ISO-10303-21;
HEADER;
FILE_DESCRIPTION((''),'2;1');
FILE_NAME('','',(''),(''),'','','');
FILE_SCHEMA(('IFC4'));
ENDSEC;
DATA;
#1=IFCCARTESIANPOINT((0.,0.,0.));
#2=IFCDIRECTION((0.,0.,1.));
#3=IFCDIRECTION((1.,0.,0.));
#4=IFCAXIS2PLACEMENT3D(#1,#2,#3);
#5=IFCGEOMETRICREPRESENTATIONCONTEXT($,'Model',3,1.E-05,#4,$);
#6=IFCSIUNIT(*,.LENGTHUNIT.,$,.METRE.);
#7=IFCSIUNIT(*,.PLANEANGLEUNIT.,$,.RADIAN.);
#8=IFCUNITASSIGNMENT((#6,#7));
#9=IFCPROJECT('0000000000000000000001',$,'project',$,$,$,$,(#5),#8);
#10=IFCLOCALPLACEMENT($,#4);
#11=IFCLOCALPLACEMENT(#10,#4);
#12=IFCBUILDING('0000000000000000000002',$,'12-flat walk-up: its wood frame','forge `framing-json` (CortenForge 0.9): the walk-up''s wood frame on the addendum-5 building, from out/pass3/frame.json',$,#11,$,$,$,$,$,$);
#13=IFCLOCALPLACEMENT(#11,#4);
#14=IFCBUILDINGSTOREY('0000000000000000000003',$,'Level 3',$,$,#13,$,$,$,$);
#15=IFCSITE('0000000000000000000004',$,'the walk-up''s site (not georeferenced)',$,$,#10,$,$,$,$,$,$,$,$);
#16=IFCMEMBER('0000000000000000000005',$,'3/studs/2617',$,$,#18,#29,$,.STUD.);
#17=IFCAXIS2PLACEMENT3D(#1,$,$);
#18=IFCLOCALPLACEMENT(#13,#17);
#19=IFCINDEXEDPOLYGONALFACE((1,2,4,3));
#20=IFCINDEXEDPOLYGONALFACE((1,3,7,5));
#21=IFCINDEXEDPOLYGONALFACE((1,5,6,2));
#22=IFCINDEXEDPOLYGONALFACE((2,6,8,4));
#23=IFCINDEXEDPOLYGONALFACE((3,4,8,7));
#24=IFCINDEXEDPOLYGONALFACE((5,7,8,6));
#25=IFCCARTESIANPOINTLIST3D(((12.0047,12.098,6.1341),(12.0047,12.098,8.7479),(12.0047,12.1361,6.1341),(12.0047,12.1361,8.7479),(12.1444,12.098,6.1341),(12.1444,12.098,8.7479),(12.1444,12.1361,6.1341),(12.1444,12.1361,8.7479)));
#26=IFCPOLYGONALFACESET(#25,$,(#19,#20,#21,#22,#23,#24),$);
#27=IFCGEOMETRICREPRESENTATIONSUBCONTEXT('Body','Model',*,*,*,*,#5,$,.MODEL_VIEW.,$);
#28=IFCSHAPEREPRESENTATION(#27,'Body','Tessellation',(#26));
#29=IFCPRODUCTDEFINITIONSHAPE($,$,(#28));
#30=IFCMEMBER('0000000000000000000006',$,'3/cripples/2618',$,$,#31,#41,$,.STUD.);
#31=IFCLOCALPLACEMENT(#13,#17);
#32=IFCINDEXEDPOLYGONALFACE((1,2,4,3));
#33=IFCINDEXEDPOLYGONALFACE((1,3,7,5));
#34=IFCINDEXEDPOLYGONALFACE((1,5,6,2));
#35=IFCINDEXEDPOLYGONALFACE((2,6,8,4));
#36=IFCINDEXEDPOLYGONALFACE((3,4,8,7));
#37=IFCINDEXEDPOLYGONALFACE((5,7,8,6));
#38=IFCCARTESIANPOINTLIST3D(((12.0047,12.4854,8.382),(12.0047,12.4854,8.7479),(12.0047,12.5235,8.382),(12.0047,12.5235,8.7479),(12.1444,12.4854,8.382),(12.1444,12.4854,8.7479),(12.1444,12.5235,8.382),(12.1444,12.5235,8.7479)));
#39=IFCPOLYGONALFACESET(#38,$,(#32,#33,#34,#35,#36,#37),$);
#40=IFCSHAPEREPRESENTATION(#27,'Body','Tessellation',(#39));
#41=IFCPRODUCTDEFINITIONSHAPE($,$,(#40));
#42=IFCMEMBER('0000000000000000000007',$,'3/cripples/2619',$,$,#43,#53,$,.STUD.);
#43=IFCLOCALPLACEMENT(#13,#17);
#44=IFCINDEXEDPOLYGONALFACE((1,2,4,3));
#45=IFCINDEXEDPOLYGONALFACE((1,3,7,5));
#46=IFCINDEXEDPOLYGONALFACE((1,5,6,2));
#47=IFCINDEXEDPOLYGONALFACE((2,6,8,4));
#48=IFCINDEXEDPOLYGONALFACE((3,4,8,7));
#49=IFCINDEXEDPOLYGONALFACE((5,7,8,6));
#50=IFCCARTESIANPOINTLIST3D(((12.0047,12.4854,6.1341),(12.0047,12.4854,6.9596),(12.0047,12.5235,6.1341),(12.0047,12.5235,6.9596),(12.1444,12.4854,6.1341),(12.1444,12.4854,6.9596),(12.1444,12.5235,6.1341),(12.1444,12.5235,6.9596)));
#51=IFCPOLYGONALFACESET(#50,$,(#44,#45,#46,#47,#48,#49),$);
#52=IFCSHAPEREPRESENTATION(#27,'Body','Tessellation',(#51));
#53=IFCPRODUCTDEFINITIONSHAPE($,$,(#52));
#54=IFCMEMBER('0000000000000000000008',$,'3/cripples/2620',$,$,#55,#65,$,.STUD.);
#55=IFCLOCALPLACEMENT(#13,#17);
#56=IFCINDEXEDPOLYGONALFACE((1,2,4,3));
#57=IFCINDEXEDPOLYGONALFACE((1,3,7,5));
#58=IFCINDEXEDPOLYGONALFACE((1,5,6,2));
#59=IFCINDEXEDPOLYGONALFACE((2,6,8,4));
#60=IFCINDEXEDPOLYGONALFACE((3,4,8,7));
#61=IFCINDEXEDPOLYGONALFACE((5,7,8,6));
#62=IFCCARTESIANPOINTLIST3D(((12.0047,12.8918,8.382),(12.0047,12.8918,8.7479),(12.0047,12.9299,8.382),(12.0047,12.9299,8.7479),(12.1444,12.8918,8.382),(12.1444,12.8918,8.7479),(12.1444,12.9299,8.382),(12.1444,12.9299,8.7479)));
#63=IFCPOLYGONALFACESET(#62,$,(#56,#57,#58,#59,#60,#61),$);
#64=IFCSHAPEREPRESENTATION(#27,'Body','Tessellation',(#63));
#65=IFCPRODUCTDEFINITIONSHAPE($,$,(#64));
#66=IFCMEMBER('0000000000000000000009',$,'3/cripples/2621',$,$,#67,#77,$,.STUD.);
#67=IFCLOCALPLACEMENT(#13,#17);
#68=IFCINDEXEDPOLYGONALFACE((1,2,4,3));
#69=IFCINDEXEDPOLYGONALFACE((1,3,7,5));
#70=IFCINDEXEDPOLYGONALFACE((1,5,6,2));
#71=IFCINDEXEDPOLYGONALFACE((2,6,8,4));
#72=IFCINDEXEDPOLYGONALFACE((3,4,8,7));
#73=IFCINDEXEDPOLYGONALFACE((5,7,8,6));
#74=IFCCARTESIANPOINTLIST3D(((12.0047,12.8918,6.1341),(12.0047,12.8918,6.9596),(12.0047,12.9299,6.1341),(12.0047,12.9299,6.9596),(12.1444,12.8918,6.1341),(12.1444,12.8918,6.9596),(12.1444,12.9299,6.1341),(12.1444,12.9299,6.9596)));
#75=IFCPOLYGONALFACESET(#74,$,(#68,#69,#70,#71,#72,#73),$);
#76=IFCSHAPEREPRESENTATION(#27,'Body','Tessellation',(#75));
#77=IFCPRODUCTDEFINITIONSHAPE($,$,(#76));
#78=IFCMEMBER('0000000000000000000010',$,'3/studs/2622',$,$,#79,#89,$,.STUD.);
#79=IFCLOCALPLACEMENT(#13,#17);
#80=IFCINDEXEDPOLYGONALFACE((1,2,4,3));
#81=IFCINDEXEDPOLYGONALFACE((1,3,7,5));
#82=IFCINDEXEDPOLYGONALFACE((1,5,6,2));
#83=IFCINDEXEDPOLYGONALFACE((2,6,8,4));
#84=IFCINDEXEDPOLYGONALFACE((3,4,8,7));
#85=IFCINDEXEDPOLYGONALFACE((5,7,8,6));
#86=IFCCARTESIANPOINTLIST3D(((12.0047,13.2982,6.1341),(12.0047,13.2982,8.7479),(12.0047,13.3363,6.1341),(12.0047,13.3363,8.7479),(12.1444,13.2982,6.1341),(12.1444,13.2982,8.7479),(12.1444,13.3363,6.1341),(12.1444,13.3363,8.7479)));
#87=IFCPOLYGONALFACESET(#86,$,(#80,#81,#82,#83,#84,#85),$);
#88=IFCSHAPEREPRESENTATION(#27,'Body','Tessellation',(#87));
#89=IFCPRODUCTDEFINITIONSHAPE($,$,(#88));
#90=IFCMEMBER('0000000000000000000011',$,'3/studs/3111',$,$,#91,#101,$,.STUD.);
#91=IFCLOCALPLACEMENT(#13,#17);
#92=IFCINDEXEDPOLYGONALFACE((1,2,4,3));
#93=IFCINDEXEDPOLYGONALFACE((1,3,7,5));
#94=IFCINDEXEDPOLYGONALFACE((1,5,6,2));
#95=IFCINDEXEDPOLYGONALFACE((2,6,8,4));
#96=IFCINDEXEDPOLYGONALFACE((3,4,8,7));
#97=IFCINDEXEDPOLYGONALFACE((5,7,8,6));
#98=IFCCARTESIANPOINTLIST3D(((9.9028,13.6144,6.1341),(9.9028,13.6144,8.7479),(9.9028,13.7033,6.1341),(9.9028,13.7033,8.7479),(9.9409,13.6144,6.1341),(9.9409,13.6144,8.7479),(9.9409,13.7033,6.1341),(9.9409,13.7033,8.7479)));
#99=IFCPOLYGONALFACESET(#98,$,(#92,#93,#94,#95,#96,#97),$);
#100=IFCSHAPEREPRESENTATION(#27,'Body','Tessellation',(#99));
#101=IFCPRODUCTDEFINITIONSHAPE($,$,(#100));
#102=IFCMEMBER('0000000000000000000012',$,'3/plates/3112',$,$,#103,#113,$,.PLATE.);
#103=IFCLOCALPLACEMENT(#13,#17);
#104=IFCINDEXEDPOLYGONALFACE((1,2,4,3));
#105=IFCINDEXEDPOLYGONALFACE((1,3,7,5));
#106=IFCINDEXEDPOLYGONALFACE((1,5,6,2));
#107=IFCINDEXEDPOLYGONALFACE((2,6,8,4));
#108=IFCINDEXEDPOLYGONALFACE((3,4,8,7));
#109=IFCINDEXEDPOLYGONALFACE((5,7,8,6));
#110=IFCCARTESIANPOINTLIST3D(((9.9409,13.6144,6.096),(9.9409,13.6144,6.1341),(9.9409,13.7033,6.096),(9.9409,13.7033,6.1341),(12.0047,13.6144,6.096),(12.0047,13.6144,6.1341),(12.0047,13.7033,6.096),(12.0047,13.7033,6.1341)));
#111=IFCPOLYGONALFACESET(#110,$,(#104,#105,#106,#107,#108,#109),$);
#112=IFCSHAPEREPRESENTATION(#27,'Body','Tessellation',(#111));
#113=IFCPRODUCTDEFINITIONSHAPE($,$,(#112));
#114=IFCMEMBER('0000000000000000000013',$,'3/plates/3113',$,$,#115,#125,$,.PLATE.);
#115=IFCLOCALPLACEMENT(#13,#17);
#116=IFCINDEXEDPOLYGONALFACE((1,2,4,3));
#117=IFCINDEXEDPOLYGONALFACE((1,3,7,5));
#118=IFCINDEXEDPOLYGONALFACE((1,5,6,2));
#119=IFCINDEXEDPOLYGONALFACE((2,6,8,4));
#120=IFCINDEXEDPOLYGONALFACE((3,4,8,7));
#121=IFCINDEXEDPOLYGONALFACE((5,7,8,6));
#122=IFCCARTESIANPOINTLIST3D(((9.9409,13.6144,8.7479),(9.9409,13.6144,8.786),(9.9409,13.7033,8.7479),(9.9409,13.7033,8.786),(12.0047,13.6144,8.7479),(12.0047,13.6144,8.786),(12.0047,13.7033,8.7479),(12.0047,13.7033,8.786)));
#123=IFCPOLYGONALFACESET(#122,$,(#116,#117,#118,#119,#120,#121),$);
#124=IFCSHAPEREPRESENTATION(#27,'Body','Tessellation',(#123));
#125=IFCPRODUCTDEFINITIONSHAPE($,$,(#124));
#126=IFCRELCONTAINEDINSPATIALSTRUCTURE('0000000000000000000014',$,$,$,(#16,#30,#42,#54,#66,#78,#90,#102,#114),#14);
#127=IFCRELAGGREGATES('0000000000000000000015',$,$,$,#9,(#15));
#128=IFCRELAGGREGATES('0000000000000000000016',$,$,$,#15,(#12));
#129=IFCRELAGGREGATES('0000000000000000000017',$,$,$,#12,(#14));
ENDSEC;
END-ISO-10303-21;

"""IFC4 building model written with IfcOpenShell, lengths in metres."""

from ifc_helpers import new_model, si_unit, frame, frame_2d, origin, origin_with_axes, place, context, subcontext, project, spatial, rectangle, extrude, element, save


model = new_model("IFC4")

# Units and contexts
model_context = context("Model", 3, precision=1e-05, world=origin_with_axes())
body_context = subcontext(model_context, "Body", "Model", "MODEL_VIEW")
ifc_project = project(units=[si_unit("LENGTHUNIT", "METRE"), si_unit("PLANEANGLEUNIT", "RADIAN")], contexts=[model_context])

# Site, building, storey
site_placement = place(None, origin_with_axes())
site = spatial("IfcSite", under=ifc_project, at=site_placement, Name="the walk-up's site (not georeferenced)")
building_placement = place(site_placement, origin_with_axes())
building = spatial("IfcBuilding", under=site, at=building_placement, Name="12-flat walk-up: its wood frame", Description="forge `framing-json` (CortenForge 0.9): the walk-up's wood frame on the addendum-5 building, from out/pass3/frame.json")
storey_placement = place(building_placement, origin_with_axes())
storey = spatial("IfcBuildingStorey", under=building, at=storey_placement, Name="Level 3")

# Members
member_1_placement = place(storey_placement, frame((12.0047, 12.098, 6.1341), z_axis=(0.0, 0.0, 1.0), x_axis=(1.0, 0.0, 0.0)))
element("IfcMember", 1, at=member_1_placement, inside=storey, Name="3/studs/2617", PredefinedType="STUD", context=body_context, shape_type="SweptSolid", body=[
    extrude(rectangle(XDim=0.1397, YDim=0.0381, at=frame_2d((0.0698, 0.0191))), origin(), (0.0, 0.0, 1.0), 2.6138),
])
member_2_placement = place(storey_placement, frame((12.0047, 12.4854, 8.382), z_axis=(0.0, 0.0, 1.0), x_axis=(1.0, 0.0, 0.0)))
element("IfcMember", 2, at=member_2_placement, inside=storey, Name="3/cripples/2618", PredefinedType="STUD", context=body_context, shape_type="SweptSolid", body=[
    extrude(rectangle(XDim=0.1397, YDim=0.0381, at=frame_2d((0.0698, 0.0191))), origin(), (0.0, 0.0, 1.0), 0.3659),
])
member_3_placement = place(storey_placement, frame((12.0047, 12.4854, 6.1341), z_axis=(0.0, 0.0, 1.0), x_axis=(1.0, 0.0, 0.0)))
element("IfcMember", 3, at=member_3_placement, inside=storey, Name="3/cripples/2619", PredefinedType="STUD", context=body_context, shape_type="SweptSolid", body=[
    extrude(rectangle(XDim=0.1397, YDim=0.0381, at=frame_2d((0.0698, 0.0191))), origin(), (0.0, 0.0, 1.0), 0.8255),
])
member_4_placement = place(storey_placement, frame((12.0047, 12.8918, 8.382), z_axis=(0.0, 0.0, 1.0), x_axis=(1.0, 0.0, 0.0)))
element("IfcMember", 4, at=member_4_placement, inside=storey, Name="3/cripples/2620", PredefinedType="STUD", context=body_context, shape_type="SweptSolid", body=[
    extrude(rectangle(XDim=0.1397, YDim=0.0381, at=frame_2d((0.0698, 0.019))), origin(), (0.0, 0.0, 1.0), 0.3659),
])
member_5_placement = place(storey_placement, frame((12.0047, 12.8918, 6.1341), z_axis=(0.0, 0.0, 1.0), x_axis=(1.0, 0.0, 0.0)))
element("IfcMember", 5, at=member_5_placement, inside=storey, Name="3/cripples/2621", PredefinedType="STUD", context=body_context, shape_type="SweptSolid", body=[
    extrude(rectangle(XDim=0.1397, YDim=0.0381, at=frame_2d((0.0698, 0.019))), origin(), (0.0, 0.0, 1.0), 0.8255),
])
member_6_placement = place(storey_placement, frame((12.0047, 13.2982, 6.1341), z_axis=(0.0, 0.0, 1.0), x_axis=(1.0, 0.0, 0.0)))
element("IfcMember", 6, at=member_6_placement, inside=storey, Name="3/studs/2622", PredefinedType="STUD", context=body_context, shape_type="SweptSolid", body=[
    extrude(rectangle(XDim=0.1397, YDim=0.0381, at=frame_2d((0.0698, 0.0191))), origin(), (0.0, 0.0, 1.0), 2.6138),
])
member_7_placement = place(storey_placement, frame((9.9028, 13.6144, 6.1341), z_axis=(0.0, 0.0, 1.0), x_axis=(1.0, 0.0, 0.0)))
element("IfcMember", 7, at=member_7_placement, inside=storey, Name="3/studs/3111", PredefinedType="STUD", context=body_context, shape_type="SweptSolid", body=[
    extrude(rectangle(XDim=0.0381, YDim=0.0889, at=frame_2d((0.0191, 0.0445))), origin(), (0.0, 0.0, 1.0), 2.6138),
])
for number, where, z_axis, x_axis, name in (
    (8, (9.9409, 13.6144, 6.096), (0.0, 0.0, 1.0), (1.0, 0.0, 0.0), "3/plates/3112"),
    (9, (9.9409, 13.6144, 8.7479), (0.0, 0.0, 1.0), (1.0, 0.0, 0.0), "3/plates/3113"),
):
    element("IfcMember", number, at=place(storey_placement, frame(where, z_axis=z_axis, x_axis=x_axis)), inside=storey, Name=name, PredefinedType="PLATE", context=body_context, shape_type="SweptSolid", body=[
        extrude(rectangle(XDim=2.0638, YDim=0.0889, at=frame_2d((1.0319, 0.0445))), origin(), (0.0, 0.0, 1.0), 0.0381),
    ])

save(model, "model.ifc")
